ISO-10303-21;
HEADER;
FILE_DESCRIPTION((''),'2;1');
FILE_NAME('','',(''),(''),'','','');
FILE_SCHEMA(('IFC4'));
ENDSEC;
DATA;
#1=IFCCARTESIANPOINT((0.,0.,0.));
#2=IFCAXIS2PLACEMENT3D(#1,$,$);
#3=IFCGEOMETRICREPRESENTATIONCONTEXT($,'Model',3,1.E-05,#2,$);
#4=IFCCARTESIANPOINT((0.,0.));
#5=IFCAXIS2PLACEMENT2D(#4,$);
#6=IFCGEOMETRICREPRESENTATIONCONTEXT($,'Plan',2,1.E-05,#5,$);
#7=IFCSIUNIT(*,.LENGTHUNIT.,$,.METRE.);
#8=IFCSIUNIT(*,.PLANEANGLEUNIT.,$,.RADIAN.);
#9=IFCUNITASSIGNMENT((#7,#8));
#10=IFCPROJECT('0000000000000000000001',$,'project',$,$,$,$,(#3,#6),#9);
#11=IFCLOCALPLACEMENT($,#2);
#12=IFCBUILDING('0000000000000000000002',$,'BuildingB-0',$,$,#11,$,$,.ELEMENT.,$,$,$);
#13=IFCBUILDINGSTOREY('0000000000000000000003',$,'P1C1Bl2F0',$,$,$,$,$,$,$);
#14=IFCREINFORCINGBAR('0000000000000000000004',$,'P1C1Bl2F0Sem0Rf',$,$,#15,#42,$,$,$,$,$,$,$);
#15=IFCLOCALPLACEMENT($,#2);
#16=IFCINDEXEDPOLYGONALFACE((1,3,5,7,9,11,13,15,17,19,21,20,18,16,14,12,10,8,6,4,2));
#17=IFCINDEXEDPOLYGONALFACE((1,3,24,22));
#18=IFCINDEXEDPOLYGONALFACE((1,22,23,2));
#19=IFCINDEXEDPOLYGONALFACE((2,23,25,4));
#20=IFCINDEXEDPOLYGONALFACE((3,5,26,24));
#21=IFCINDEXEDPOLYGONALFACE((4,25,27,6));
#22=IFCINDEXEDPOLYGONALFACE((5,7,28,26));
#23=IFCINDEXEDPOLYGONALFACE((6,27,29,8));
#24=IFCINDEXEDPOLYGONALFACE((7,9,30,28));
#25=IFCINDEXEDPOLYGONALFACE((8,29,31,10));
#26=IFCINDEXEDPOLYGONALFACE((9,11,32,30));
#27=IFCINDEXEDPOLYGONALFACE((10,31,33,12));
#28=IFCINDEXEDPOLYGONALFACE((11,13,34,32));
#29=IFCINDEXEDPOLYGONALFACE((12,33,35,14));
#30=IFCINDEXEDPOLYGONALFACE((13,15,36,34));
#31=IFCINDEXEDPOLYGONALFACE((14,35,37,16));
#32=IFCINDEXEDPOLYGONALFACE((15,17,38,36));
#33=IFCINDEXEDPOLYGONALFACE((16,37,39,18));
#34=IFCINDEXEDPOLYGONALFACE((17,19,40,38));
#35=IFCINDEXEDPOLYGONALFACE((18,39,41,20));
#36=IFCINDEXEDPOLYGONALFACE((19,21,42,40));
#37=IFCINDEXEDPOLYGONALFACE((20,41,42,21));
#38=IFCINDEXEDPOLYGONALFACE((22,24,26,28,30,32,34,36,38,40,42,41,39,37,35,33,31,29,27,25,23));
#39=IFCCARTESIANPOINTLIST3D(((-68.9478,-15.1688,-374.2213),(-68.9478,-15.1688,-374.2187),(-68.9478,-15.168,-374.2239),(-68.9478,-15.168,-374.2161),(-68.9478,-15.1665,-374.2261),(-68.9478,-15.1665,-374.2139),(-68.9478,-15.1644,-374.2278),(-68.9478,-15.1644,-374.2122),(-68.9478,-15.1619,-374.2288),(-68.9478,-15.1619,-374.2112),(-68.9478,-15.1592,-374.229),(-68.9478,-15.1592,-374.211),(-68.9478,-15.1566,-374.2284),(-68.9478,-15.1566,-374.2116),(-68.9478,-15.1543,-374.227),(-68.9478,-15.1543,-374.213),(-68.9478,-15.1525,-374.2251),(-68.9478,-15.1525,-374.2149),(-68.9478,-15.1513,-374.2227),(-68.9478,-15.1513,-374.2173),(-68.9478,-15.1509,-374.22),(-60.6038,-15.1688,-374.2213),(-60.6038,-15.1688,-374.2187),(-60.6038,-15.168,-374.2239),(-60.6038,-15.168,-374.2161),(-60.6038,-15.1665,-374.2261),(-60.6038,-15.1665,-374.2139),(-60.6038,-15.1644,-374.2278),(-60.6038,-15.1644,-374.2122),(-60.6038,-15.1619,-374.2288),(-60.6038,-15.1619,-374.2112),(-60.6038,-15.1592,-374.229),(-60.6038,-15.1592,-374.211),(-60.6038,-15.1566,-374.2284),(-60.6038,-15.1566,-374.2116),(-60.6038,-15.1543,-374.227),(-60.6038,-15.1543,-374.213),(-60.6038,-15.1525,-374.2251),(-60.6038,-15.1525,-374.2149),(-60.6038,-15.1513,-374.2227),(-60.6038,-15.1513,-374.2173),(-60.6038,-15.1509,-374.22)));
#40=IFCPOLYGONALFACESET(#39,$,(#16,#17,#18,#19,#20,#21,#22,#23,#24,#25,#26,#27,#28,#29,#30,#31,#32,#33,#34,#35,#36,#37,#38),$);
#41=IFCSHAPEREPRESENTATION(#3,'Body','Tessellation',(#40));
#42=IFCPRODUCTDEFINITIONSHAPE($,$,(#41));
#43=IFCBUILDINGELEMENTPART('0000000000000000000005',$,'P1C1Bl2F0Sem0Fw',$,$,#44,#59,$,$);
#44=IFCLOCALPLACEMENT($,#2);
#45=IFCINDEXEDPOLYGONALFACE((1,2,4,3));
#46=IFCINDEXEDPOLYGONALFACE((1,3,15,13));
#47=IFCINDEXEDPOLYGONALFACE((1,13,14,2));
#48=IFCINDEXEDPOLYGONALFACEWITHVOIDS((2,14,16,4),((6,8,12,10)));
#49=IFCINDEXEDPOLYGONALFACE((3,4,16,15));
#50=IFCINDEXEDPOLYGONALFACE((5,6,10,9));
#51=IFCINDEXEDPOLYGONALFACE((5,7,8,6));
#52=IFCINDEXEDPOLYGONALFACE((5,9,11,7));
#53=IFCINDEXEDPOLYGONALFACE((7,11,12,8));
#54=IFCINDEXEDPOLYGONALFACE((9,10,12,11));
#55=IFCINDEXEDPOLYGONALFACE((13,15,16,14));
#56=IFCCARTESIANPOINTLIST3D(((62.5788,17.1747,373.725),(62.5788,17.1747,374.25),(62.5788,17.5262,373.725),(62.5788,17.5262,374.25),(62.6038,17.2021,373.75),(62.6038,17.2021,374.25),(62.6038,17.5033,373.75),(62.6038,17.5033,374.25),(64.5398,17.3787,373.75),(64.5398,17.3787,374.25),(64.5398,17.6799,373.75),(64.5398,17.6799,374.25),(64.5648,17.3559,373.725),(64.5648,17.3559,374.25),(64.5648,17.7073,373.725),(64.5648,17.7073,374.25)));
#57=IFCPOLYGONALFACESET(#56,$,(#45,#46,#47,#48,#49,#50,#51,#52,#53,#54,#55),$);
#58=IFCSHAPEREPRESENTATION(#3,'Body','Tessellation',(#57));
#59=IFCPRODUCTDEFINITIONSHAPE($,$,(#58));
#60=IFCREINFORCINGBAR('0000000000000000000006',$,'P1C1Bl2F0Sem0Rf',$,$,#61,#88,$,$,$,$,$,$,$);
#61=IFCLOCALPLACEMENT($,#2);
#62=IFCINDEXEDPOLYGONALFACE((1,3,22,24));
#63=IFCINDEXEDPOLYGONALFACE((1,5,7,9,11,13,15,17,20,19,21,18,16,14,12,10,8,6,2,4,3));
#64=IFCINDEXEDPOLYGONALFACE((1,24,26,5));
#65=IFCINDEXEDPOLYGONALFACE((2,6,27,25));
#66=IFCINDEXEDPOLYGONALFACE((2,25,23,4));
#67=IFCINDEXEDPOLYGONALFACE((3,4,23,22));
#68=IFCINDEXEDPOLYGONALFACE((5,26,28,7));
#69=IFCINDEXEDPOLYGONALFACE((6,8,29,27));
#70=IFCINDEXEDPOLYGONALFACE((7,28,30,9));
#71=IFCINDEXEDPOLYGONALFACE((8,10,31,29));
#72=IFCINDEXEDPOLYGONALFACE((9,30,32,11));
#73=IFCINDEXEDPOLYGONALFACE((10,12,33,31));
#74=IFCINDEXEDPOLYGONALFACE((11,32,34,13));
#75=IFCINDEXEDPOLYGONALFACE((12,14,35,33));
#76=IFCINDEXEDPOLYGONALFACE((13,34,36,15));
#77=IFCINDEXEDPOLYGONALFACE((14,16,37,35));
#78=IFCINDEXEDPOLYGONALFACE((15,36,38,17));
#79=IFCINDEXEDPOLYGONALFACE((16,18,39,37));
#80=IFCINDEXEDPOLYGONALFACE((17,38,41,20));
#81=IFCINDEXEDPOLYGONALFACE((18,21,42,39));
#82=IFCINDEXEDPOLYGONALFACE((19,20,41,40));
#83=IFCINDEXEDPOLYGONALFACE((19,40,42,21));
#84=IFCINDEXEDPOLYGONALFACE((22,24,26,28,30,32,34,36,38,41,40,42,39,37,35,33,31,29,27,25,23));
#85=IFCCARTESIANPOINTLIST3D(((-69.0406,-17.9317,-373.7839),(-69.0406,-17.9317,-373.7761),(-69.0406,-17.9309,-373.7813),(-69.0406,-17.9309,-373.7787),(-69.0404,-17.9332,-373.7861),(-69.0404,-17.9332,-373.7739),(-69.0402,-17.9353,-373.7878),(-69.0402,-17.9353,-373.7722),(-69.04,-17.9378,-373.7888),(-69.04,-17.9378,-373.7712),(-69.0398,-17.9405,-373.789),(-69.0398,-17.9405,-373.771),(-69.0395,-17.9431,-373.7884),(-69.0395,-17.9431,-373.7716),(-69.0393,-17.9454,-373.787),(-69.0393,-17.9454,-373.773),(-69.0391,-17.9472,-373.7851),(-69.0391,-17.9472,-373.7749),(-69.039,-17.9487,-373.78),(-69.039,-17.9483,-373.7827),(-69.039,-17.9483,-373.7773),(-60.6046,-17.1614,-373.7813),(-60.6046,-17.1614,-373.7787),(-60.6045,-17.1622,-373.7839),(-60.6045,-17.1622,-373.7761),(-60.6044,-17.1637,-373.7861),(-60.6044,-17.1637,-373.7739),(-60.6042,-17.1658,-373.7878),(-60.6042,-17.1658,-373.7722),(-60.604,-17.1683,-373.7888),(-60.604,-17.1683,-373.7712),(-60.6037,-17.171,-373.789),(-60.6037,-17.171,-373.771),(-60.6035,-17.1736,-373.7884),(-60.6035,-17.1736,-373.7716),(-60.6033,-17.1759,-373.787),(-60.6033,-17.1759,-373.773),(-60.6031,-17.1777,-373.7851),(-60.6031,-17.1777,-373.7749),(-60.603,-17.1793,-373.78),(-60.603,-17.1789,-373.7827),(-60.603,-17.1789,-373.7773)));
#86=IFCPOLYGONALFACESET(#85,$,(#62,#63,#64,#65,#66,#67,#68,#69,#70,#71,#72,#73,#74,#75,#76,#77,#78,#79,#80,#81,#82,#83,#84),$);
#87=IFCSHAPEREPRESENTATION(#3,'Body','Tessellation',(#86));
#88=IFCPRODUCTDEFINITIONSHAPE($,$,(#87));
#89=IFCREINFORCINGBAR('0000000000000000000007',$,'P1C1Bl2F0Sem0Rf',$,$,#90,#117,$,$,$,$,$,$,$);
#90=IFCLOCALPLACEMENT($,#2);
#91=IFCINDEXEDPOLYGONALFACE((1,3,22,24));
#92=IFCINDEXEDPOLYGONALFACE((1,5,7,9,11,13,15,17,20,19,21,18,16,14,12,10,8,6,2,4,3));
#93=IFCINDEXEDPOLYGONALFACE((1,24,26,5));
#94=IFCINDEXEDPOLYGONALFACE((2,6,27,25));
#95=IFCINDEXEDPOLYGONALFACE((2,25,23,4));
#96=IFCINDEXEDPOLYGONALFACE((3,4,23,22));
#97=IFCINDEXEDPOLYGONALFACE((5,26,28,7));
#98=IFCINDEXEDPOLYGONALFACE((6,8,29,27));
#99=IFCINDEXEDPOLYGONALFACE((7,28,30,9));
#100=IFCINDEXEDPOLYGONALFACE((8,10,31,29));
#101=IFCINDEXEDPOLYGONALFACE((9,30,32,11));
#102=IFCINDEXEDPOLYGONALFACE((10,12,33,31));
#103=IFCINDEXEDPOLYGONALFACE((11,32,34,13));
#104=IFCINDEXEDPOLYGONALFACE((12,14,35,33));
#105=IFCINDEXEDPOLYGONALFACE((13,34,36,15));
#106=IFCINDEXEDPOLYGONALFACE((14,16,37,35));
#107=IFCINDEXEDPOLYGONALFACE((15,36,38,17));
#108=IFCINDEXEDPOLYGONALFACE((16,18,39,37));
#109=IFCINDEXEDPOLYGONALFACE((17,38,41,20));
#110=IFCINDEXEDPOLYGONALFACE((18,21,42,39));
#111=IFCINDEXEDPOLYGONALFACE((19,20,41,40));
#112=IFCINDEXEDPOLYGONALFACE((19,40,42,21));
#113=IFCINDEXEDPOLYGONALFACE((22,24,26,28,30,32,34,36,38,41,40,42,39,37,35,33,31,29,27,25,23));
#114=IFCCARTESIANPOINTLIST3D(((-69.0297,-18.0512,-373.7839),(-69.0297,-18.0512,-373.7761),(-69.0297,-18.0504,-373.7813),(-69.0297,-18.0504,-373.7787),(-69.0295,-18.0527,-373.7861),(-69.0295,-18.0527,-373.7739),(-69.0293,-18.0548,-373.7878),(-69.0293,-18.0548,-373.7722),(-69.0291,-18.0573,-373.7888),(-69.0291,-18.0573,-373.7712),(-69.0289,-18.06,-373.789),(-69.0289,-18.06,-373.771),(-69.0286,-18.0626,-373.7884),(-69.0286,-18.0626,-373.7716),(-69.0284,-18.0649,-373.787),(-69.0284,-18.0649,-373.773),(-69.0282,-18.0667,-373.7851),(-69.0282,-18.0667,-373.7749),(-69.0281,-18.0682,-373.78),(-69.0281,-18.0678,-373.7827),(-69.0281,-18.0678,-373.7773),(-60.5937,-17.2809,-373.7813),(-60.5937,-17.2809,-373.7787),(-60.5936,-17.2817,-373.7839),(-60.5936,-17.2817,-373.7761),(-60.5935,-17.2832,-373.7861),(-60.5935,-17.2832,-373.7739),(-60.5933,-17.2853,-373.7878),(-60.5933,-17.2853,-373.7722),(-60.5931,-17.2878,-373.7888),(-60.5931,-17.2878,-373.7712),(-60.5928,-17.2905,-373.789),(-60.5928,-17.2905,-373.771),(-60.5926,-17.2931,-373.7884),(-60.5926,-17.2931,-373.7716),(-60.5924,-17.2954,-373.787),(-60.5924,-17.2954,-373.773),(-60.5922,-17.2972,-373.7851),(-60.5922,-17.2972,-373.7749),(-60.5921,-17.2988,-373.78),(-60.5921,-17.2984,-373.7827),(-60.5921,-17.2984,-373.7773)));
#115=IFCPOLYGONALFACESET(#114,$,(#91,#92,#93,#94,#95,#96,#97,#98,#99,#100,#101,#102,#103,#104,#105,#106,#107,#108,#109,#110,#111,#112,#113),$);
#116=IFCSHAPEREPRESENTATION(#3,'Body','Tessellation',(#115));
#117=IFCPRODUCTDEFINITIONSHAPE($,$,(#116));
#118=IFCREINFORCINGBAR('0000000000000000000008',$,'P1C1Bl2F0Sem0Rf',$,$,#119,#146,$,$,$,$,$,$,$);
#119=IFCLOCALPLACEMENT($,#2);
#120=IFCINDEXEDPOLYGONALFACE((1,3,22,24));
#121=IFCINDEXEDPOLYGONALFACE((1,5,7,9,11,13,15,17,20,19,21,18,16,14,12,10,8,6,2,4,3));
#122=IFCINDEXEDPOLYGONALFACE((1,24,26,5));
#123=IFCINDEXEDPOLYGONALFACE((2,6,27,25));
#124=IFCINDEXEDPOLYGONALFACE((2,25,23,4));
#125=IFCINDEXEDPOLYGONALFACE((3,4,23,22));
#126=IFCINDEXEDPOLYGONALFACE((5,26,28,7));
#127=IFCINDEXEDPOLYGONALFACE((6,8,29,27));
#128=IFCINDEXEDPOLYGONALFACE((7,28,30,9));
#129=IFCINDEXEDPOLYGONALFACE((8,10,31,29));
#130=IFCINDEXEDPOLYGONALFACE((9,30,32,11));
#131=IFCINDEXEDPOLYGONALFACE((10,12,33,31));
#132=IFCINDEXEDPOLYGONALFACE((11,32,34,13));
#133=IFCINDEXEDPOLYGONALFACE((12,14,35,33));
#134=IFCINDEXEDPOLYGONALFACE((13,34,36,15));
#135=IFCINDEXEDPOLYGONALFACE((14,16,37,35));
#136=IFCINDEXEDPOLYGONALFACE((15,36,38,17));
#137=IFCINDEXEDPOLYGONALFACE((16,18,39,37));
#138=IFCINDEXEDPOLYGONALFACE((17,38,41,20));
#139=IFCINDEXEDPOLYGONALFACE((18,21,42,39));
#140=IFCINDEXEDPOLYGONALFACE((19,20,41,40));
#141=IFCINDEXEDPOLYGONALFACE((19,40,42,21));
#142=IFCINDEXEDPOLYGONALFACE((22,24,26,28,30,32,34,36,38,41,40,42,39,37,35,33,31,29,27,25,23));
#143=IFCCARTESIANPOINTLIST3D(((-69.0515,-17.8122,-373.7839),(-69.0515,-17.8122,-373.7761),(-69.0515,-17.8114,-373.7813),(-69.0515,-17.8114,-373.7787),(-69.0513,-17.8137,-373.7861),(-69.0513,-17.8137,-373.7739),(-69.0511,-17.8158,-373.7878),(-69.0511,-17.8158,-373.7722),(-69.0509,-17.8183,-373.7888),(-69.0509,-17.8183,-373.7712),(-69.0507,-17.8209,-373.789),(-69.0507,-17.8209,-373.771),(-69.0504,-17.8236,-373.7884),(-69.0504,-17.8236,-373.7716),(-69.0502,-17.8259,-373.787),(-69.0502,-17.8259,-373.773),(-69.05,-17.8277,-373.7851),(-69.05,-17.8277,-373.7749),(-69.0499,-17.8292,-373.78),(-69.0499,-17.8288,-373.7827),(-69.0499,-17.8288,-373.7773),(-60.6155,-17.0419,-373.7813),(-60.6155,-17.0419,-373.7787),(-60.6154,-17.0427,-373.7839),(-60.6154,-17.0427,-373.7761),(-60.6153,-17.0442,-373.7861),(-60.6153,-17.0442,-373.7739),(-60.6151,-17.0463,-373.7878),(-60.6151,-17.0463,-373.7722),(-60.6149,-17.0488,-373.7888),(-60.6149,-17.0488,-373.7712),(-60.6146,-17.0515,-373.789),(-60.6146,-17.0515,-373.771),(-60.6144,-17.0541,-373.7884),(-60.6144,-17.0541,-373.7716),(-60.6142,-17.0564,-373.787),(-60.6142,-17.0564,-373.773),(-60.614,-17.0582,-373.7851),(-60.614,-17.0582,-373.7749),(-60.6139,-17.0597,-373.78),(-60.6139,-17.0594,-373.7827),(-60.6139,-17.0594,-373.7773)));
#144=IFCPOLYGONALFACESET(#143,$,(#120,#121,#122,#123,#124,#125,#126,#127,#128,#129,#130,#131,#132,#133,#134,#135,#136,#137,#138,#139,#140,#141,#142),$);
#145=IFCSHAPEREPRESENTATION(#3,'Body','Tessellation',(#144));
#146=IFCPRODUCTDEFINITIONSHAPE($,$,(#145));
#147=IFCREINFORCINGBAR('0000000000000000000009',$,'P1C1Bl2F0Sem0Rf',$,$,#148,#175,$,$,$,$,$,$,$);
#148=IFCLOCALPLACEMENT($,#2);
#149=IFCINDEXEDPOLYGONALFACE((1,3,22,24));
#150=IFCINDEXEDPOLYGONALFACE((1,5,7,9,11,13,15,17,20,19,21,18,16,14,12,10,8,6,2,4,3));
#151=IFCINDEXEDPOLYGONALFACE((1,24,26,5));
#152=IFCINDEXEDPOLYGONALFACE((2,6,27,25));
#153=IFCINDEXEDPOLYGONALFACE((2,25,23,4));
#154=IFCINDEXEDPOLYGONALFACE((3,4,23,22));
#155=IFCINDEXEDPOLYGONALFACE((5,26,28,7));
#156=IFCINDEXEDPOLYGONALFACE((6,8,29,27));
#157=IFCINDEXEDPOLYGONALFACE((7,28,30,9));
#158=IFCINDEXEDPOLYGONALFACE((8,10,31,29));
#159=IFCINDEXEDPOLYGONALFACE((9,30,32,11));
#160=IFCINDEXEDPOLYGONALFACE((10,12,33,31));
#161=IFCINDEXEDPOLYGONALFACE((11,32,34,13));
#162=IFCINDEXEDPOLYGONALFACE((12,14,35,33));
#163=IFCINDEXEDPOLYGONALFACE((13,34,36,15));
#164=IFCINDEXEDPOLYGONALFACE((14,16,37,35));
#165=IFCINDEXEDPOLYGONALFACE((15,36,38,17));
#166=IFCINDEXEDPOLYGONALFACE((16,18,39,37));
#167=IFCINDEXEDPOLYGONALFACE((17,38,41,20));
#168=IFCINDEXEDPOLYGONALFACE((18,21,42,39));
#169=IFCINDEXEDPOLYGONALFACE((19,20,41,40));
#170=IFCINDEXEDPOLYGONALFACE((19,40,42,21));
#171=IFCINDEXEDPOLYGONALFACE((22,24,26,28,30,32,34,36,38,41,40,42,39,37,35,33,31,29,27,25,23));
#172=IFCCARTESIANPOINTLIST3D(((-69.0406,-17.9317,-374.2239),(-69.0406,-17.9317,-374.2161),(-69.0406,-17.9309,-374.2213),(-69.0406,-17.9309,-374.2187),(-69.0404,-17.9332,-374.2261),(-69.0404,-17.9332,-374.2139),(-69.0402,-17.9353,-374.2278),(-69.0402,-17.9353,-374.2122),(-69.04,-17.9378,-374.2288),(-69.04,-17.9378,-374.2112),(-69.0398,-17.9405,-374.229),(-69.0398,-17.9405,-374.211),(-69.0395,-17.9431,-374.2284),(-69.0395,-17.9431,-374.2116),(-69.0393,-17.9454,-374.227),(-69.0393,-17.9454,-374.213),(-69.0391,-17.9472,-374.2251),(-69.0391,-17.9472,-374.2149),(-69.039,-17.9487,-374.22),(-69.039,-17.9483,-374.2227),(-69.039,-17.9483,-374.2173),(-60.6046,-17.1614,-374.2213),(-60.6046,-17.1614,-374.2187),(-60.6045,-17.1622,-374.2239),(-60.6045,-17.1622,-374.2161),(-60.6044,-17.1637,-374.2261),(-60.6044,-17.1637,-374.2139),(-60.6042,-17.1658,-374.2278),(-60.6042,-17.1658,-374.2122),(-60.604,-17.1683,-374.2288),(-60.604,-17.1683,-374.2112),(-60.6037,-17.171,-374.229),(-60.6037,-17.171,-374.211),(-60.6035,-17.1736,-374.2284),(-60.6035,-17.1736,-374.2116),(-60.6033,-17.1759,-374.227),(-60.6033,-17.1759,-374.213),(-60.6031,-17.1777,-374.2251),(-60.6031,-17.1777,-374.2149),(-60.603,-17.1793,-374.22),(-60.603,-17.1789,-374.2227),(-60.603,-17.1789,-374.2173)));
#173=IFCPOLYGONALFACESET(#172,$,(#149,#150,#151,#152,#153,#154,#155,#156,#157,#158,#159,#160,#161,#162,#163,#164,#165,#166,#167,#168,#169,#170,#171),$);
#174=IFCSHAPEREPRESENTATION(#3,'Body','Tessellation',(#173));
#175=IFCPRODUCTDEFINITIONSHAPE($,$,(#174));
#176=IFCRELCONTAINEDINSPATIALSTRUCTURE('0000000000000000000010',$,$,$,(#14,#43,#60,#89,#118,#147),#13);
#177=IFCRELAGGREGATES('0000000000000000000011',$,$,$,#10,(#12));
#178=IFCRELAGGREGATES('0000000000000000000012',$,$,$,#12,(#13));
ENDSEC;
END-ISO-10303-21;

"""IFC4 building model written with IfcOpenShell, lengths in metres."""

from ifc_helpers import new_model, entity, si_unit, origin, origin_2d, place, context, project, spatial, polyline, outline, extrude, element, save


model = new_model("IFC4")

# Units and contexts
model_context = context("Model", 3, precision=1e-05, world=origin())
plan_context = context("Plan", 2, precision=1e-05, world=origin_2d())
ifc_project = project(units=[si_unit("LENGTHUNIT", "METRE"), si_unit("PLANEANGLEUNIT", "RADIAN")], contexts=[model_context, plan_context])

# Building, storey
building_placement = place(None, origin())
building = spatial("IfcBuilding", under=ifc_project, at=building_placement, Name="BuildingB-0", CompositionType="ELEMENT")
storey = spatial("IfcBuildingStorey", under=building, Name="P1C1Bl2F0")

# Reinforcing bar
element("IfcReinforcingBar", 1, inside=storey, Name="P1C1Bl2F0Sem0Rf", context=model_context, shape_type="SweptSolid", body=[
    entity("IfcSurfaceCurveSweptAreaSolid", entity("IfcCircleProfileDef", "AREA", None, None, 0.009), None, entity("IfcPolyline", [entity("IfcCartesianPoint", [60.6038, 15.1599, 374.22]), entity("IfcCartesianPoint", [68.9478, 15.1599, 374.22])]), None, None, entity("IfcPlane", entity("IfcAxis2Placement3D", entity("IfcCartesianPoint", [60.6038, 15.1599, 374.22]), entity("IfcDirection", [0.0, 0.0, 1.0]), entity("IfcDirection", [1.0, 0.0, 0.0])))),
])

# Building element part, opening
building_element_part_1 = element("IfcBuildingElementPart", 2, inside=storey, Name="P1C1Bl2F0Sem0Fw", context=model_context, shape_type="SweptSolid", body=[
    extrude(outline(polyline([(64.5648, 17.3559, 373.725), (64.5648, 17.7073, 373.725), (62.5788, 17.5262, 373.725), (62.5788, 17.1747, 373.725), (64.5648, 17.3559, 373.725)])), None, (0.0, 0.0, 1.0), 0.525),
])
element("IfcOpeningElement", 3, inside=storey, cuts=building_element_part_1, context=model_context, shape_type="SweptSolid", body=[
    extrude(outline(polyline([(64.5398, 17.3787, 373.75), (64.5398, 17.6799, 373.75), (62.6038, 17.5033, 373.75), (62.6038, 17.2021, 373.75), (64.5398, 17.3787, 373.75)])), None, (0.0, 0.0, 1.0), 0.5),
])

# Reinforcing bars
element("IfcReinforcingBar", 4, inside=storey, Name="P1C1Bl2F0Sem0Rf", context=model_context, shape_type="SweptSolid", body=[
    entity("IfcSurfaceCurveSweptAreaSolid", entity("IfcCircleProfileDef", "AREA", None, None, 0.009), None, entity("IfcPolyline", [entity("IfcCartesianPoint", [69.0398, 17.9398, 373.78]), entity("IfcCartesianPoint", [60.6038, 17.1703, 373.78])]), None, None, entity("IfcPlane", entity("IfcAxis2Placement3D", entity("IfcCartesianPoint", [69.0398, 17.9398, 373.78]), entity("IfcDirection", [0.0, 0.0, 1.0]), entity("IfcDirection", [1.0, 0.0, 0.0])))),
])
element("IfcReinforcingBar", 5, inside=storey, Name="P1C1Bl2F0Sem0Rf", context=model_context, shape_type="SweptSolid", body=[
    entity("IfcSurfaceCurveSweptAreaSolid", entity("IfcCircleProfileDef", "AREA", None, None, 0.009), None, entity("IfcPolyline", [entity("IfcCartesianPoint", [69.0289, 18.0593, 373.78]), entity("IfcCartesianPoint", [60.5929, 17.2898, 373.78])]), None, None, entity("IfcPlane", entity("IfcAxis2Placement3D", entity("IfcCartesianPoint", [69.0289, 18.0593, 373.78]), entity("IfcDirection", [0.0, 0.0, 1.0]), entity("IfcDirection", [1.0, 0.0, 0.0])))),
])
element("IfcReinforcingBar", 6, inside=storey, Name="P1C1Bl2F0Sem0Rf", context=model_context, shape_type="SweptSolid", body=[
    entity("IfcSurfaceCurveSweptAreaSolid", entity("IfcCircleProfileDef", "AREA", None, None, 0.009), None, entity("IfcPolyline", [entity("IfcCartesianPoint", [69.0507, 17.8203, 373.78]), entity("IfcCartesianPoint", [60.6147, 17.0508, 373.78])]), None, None, entity("IfcPlane", entity("IfcAxis2Placement3D", entity("IfcCartesianPoint", [69.0507, 17.8203, 373.78]), entity("IfcDirection", [0.0, 0.0, 1.0]), entity("IfcDirection", [1.0, 0.0, 0.0])))),
])
element("IfcReinforcingBar", 7, inside=storey, Name="P1C1Bl2F0Sem0Rf", context=model_context, shape_type="SweptSolid", body=[
    entity("IfcSurfaceCurveSweptAreaSolid", entity("IfcCircleProfileDef", "AREA", None, None, 0.009), None, entity("IfcPolyline", [entity("IfcCartesianPoint", [69.0398, 17.9398, 374.22]), entity("IfcCartesianPoint", [60.6038, 17.1703, 374.22])]), None, None, entity("IfcPlane", entity("IfcAxis2Placement3D", entity("IfcCartesianPoint", [69.0398, 17.9398, 374.22]), entity("IfcDirection", [0.0, 0.0, 1.0]), entity("IfcDirection", [1.0, 0.0, 0.0])))),
])

save(model, "model.ifc")
